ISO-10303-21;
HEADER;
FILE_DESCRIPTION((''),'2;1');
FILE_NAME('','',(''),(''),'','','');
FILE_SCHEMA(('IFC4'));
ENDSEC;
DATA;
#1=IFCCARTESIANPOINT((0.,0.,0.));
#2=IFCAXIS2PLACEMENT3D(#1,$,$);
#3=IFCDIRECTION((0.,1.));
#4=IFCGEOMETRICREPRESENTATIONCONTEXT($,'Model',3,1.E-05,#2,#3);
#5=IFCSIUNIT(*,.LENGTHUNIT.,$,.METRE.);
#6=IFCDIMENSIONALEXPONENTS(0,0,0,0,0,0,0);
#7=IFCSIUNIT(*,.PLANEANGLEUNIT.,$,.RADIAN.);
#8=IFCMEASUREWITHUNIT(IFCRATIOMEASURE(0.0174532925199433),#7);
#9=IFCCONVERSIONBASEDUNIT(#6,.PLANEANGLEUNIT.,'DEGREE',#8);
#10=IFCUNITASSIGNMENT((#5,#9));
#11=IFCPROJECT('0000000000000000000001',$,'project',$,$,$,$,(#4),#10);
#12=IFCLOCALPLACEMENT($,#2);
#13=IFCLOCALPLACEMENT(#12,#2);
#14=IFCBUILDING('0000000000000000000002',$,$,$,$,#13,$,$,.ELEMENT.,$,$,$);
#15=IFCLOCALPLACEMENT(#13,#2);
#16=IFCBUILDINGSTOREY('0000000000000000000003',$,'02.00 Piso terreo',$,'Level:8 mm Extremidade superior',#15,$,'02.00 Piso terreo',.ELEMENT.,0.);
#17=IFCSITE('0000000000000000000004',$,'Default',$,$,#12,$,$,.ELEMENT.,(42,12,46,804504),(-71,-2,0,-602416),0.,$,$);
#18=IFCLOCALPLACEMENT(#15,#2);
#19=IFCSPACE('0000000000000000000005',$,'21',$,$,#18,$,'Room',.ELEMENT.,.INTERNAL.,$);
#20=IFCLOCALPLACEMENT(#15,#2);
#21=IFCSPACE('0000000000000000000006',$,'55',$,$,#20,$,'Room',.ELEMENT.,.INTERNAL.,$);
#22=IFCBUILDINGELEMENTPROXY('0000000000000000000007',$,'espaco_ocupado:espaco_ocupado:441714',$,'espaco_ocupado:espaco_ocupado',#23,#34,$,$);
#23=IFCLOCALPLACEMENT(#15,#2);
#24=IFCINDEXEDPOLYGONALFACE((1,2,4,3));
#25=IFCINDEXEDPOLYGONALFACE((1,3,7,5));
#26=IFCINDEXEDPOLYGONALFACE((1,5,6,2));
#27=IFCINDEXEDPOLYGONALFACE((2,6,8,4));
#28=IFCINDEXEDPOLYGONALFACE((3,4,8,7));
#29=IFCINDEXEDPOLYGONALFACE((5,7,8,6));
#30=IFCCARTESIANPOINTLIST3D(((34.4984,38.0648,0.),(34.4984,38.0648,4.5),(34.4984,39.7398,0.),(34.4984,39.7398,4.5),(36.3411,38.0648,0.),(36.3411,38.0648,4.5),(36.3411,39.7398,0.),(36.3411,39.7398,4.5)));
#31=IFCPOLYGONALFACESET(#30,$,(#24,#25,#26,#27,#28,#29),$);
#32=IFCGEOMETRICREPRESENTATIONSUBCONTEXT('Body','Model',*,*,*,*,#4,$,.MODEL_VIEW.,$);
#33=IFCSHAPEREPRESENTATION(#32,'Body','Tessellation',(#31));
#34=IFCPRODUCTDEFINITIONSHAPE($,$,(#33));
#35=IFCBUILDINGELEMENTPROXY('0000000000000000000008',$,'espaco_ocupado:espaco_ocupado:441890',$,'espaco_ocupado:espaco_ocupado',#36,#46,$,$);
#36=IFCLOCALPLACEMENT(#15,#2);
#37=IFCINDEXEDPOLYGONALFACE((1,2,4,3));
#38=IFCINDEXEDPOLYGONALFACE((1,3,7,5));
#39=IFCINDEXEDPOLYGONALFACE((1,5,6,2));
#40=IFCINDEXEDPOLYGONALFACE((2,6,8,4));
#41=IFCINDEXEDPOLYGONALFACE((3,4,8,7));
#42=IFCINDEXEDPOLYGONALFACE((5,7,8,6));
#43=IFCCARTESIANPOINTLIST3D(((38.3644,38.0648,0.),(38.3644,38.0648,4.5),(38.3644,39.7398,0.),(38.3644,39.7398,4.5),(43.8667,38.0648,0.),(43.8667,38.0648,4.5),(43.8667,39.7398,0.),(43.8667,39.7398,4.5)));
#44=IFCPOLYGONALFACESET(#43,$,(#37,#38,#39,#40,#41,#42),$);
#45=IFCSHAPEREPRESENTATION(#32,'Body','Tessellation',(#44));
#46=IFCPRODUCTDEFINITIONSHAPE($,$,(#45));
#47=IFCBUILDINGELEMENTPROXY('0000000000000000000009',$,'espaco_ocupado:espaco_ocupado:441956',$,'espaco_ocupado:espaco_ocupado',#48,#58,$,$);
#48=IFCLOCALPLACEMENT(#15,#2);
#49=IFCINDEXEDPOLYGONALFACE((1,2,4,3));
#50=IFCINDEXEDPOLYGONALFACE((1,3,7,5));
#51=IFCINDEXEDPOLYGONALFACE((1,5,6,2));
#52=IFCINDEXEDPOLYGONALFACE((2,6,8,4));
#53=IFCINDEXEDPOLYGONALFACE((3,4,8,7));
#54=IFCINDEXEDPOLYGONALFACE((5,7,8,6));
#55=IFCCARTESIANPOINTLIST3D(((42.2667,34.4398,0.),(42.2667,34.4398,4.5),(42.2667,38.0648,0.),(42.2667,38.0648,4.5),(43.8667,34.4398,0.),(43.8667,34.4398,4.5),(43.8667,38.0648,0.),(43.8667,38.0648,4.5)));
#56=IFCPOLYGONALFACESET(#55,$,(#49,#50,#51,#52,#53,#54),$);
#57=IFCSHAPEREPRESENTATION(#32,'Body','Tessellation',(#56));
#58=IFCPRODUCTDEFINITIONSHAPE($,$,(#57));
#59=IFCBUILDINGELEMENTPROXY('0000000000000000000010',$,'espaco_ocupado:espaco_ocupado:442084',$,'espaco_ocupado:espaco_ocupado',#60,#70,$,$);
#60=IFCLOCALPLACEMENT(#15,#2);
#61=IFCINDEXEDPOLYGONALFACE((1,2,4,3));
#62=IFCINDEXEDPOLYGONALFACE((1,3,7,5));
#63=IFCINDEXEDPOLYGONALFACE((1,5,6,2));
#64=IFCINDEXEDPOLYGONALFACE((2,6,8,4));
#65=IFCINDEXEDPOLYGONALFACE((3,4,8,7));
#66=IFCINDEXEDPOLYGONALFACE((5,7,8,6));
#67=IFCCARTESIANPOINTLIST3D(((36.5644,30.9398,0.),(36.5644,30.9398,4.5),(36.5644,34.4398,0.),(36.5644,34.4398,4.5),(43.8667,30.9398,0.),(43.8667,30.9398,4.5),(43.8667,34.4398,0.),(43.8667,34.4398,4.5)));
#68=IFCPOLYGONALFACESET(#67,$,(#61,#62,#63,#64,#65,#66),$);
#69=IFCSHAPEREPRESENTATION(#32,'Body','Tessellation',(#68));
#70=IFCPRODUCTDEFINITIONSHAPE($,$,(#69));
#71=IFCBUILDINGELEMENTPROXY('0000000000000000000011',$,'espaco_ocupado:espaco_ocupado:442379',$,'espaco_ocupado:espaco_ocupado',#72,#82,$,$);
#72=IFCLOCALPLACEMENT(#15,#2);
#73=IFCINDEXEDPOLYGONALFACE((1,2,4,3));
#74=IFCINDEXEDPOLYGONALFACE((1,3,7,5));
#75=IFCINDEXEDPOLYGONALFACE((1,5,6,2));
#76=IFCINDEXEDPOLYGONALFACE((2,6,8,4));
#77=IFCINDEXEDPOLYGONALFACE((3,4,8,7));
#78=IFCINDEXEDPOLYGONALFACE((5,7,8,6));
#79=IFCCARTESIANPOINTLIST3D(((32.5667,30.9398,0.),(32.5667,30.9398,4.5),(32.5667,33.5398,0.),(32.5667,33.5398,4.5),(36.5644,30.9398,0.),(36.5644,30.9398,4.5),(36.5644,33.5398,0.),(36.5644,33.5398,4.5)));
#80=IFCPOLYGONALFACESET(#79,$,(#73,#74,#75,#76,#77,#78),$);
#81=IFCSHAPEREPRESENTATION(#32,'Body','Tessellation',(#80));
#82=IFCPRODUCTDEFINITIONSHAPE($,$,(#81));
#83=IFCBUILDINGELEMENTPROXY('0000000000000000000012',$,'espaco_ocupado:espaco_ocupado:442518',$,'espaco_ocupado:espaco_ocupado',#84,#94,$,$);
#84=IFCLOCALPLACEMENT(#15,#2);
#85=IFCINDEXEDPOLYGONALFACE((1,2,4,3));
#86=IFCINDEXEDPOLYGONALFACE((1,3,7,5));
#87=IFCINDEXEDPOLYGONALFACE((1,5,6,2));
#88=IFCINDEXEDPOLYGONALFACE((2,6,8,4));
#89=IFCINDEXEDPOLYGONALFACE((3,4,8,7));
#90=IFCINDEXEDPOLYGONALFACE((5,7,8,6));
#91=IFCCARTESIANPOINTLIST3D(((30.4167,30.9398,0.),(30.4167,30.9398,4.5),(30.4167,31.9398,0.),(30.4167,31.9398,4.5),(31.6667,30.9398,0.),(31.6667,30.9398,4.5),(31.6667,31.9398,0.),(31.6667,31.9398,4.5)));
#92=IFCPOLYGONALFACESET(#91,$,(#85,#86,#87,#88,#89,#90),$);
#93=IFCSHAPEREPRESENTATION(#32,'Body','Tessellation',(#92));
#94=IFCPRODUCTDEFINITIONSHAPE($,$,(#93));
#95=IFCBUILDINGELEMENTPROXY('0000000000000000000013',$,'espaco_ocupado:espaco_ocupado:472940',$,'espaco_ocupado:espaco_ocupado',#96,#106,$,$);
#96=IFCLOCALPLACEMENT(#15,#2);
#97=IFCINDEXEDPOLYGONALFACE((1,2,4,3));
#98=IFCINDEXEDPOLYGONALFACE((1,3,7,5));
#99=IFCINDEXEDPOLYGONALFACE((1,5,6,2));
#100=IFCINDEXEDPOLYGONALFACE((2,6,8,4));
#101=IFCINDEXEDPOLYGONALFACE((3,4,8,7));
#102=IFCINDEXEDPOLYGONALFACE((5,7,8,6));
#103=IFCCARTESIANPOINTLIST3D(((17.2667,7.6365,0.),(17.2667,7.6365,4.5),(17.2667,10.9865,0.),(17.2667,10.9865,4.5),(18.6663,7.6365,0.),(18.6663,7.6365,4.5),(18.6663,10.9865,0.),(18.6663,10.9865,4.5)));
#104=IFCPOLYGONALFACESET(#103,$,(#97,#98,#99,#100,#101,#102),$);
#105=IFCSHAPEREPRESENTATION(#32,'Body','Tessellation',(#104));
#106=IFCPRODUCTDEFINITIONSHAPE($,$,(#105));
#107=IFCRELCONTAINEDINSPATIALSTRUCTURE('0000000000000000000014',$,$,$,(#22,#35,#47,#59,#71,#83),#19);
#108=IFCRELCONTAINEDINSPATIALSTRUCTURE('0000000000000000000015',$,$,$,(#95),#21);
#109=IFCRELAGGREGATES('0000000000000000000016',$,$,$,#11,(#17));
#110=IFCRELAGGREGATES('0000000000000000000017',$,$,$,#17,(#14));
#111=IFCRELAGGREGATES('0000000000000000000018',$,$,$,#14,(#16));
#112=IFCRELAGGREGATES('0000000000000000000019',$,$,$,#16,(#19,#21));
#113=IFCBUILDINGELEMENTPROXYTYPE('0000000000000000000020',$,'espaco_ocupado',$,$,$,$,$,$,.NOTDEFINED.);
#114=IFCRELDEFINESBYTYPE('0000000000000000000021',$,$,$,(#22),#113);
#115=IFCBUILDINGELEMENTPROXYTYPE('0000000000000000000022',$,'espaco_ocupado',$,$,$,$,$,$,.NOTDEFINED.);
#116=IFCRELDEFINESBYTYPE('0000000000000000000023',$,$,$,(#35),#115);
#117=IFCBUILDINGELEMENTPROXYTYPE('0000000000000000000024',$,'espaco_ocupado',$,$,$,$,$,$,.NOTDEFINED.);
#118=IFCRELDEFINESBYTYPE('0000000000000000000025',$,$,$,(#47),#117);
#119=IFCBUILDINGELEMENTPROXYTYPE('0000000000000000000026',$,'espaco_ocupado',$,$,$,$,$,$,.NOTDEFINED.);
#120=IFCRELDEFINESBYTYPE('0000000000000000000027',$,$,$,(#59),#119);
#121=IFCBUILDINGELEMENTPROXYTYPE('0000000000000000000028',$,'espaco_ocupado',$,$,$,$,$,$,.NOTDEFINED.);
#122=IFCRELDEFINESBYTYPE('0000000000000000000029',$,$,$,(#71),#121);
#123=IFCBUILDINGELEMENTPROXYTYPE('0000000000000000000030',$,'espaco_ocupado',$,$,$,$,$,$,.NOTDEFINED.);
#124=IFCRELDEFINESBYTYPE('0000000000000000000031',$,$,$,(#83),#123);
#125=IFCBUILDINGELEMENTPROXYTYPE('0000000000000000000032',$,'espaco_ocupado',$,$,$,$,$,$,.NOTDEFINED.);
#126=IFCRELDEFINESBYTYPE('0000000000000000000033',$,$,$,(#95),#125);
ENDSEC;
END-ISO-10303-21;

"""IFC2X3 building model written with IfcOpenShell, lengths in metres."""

from ifc_helpers import new_model, entity, si_unit, converted_unit, direction, frame, frame_2d, origin, origin_2d_with_axis, place, context, subcontext, project, spatial, rectangle, extrude, source, transform, mapped, type_object, type_shapes, element, save


model = new_model("IFC2X3")

# Units and contexts
model_context = context("Model", 3, precision=1e-05, world=origin(), true_north=direction((0.0, 1.0)))
body_context = subcontext(model_context, "Body", "Model", "MODEL_VIEW")
ifc_project = project(units=[si_unit("LENGTHUNIT", "METRE"), converted_unit("PLANEANGLEUNIT", "DEGREE", entity("IfcRatioMeasure", 0.0174532925199433), si_unit("PLANEANGLEUNIT", "RADIAN"), dimensions=[0, 0, 0, 0, 0, 0, 0])], contexts=[model_context])

# Site, building, storey
site_placement = place(None, origin())
site = spatial("IfcSite", under=ifc_project, at=site_placement, Name="Default", CompositionType="ELEMENT", RefLatitude=(42, 12, 46, 804504), RefLongitude=(-71, -2, 0, -602416), RefElevation=0.0)
building_placement = place(site_placement, origin())
building = spatial("IfcBuilding", under=site, at=building_placement, CompositionType="ELEMENT")
storey_placement = place(building_placement, origin())
storey = spatial("IfcBuildingStorey", under=building, at=storey_placement, Name="02.00 Piso terreo", ObjectType="Level:8 mm Extremidade superior", LongName="02.00 Piso terreo", CompositionType="ELEMENT", Elevation=0.0)

# Shared definitions
space_1_placement = place(storey_placement, origin())
space_1 = spatial("IfcSpace", under=storey, at=space_1_placement, Name="21", LongName="Room", CompositionType="ELEMENT", InteriorOrExteriorSpace="INTERNAL")

# Building element proxies
building_element_proxy_type_1 = type_object("IfcBuildingElementProxyType", Name="espaco_ocupado", PredefinedType="NOTDEFINED")
shared_shape_1 = source(origin(), body_context, "Body", "SweptSolid", [
    extrude(rectangle(XDim=1.8426, YDim=1.675, at=origin_2d_with_axis()), frame((0.0, 0.0, 0.0), z_axis=(0.0, 0.0, 1.0), x_axis=(-1.0, 0.0, 0.0)), (0.0, 0.0, 1.0), 4.5),
])
type_shapes(building_element_proxy_type_1, [shared_shape_1])
proxy_1_placement = place(space_1_placement, frame((35.4197, 38.9023, 0.0)))
element("IfcBuildingElementProxy", 1, at=proxy_1_placement, inside=space_1, type_object=building_element_proxy_type_1, Name="espaco_ocupado:espaco_ocupado:441714", ObjectType="espaco_ocupado:espaco_ocupado", context=body_context, shape_type="MappedRepresentation", body=[
    mapped(shared_shape_1, transform((0.0, 0.0, 0.0), scale=1.0)),
])
building_element_proxy_type_2 = type_object("IfcBuildingElementProxyType", Name="espaco_ocupado", PredefinedType="NOTDEFINED")
shared_shape_2 = source(origin(), body_context, "Body", "SweptSolid", [
    extrude(rectangle(XDim=5.5023, YDim=1.675, at=origin_2d_with_axis()), frame((0.0, 0.0, 0.0), z_axis=(0.0, 0.0, 1.0), x_axis=(-1.0, 0.0, 0.0)), (0.0, 0.0, 1.0), 4.5),
])
type_shapes(building_element_proxy_type_2, [shared_shape_2])
proxy_2_placement = place(space_1_placement, frame((41.1156, 38.9023, 0.0)))
element("IfcBuildingElementProxy", 2, at=proxy_2_placement, inside=space_1, type_object=building_element_proxy_type_2, Name="espaco_ocupado:espaco_ocupado:441890", ObjectType="espaco_ocupado:espaco_ocupado", context=body_context, shape_type="MappedRepresentation", body=[
    mapped(shared_shape_2, transform((0.0, 0.0, 0.0), scale=1.0)),
])
building_element_proxy_type_3 = type_object("IfcBuildingElementProxyType", Name="espaco_ocupado", PredefinedType="NOTDEFINED")
shared_shape_3 = source(origin(), body_context, "Body", "SweptSolid", [
    extrude(rectangle(XDim=1.6, YDim=3.625, at=frame_2d((0.0, 0.0), x_axis=(1.0, 0.0))), frame((0.0, 0.0, 0.0), z_axis=(0.0, 0.0, 1.0), x_axis=(-1.0, 0.0, 0.0)), (0.0, 0.0, 1.0), 4.5),
])
type_shapes(building_element_proxy_type_3, [shared_shape_3])
proxy_3_placement = place(space_1_placement, frame((43.0667, 36.2523, 0.0)))
element("IfcBuildingElementProxy", 3, at=proxy_3_placement, inside=space_1, type_object=building_element_proxy_type_3, Name="espaco_ocupado:espaco_ocupado:441956", ObjectType="espaco_ocupado:espaco_ocupado", context=body_context, shape_type="MappedRepresentation", body=[
    mapped(shared_shape_3, transform((0.0, 0.0, 0.0), scale=1.0)),
])
building_element_proxy_type_4 = type_object("IfcBuildingElementProxyType", Name="espaco_ocupado", PredefinedType="NOTDEFINED")
shared_shape_4 = source(origin(), body_context, "Body", "SweptSolid", [
    extrude(rectangle(XDim=7.3023, YDim=3.5, at=origin_2d_with_axis()), frame((0.0, 0.0, 0.0), z_axis=(0.0, 0.0, 1.0), x_axis=(-1.0, 0.0, 0.0)), (0.0, 0.0, 1.0), 4.5),
])
type_shapes(building_element_proxy_type_4, [shared_shape_4])
proxy_4_placement = place(space_1_placement, frame((40.2156, 32.6898, 0.0)))
element("IfcBuildingElementProxy", 4, at=proxy_4_placement, inside=space_1, type_object=building_element_proxy_type_4, Name="espaco_ocupado:espaco_ocupado:442084", ObjectType="espaco_ocupado:espaco_ocupado", context=body_context, shape_type="MappedRepresentation", body=[
    mapped(shared_shape_4, transform((0.0, 0.0, 0.0), scale=1.0)),
])
building_element_proxy_type_5 = type_object("IfcBuildingElementProxyType", Name="espaco_ocupado", PredefinedType="NOTDEFINED")
shared_shape_5 = source(origin(), body_context, "Body", "SweptSolid", [
    extrude(rectangle(XDim=3.9977, YDim=2.6, at=origin_2d_with_axis()), frame((0.0, 0.0, 0.0), z_axis=(0.0, 0.0, 1.0), x_axis=(-1.0, 0.0, 0.0)), (0.0, 0.0, 1.0), 4.5),
])
type_shapes(building_element_proxy_type_5, [shared_shape_5])
proxy_5_placement = place(space_1_placement, frame((34.5656, 32.2398, 0.0)))
element("IfcBuildingElementProxy", 5, at=proxy_5_placement, inside=space_1, type_object=building_element_proxy_type_5, Name="espaco_ocupado:espaco_ocupado:442379", ObjectType="espaco_ocupado:espaco_ocupado", context=body_context, shape_type="MappedRepresentation", body=[
    mapped(shared_shape_5, transform((0.0, 0.0, 0.0), scale=1.0)),
])
building_element_proxy_type_6 = type_object("IfcBuildingElementProxyType", Name="espaco_ocupado", PredefinedType="NOTDEFINED")
shared_shape_6 = source(origin(), body_context, "Body", "SweptSolid", [
    extrude(rectangle(XDim=1.25, YDim=1.0, at=origin_2d_with_axis()), frame((0.0, 0.0, 0.0), z_axis=(0.0, 0.0, 1.0), x_axis=(-1.0, 0.0, 0.0)), (0.0, 0.0, 1.0), 4.5),
])
type_shapes(building_element_proxy_type_6, [shared_shape_6])
proxy_6_placement = place(space_1_placement, frame((31.0417, 31.4398, 0.0)))
element("IfcBuildingElementProxy", 6, at=proxy_6_placement, inside=space_1, type_object=building_element_proxy_type_6, Name="espaco_ocupado:espaco_ocupado:442518", ObjectType="espaco_ocupado:espaco_ocupado", context=body_context, shape_type="MappedRepresentation", body=[
    mapped(shared_shape_6, transform((0.0, 0.0, 0.0), scale=1.0)),
])

# Shared definitions
space_2_placement = place(storey_placement, origin())
space_2 = spatial("IfcSpace", under=storey, at=space_2_placement, Name="55", LongName="Room", CompositionType="ELEMENT", InteriorOrExteriorSpace="INTERNAL")

# Building element proxy
building_element_proxy_type_7 = type_object("IfcBuildingElementProxyType", Name="espaco_ocupado", PredefinedType="NOTDEFINED")
shared_shape_7 = source(origin(), body_context, "Body", "SweptSolid", [
    extrude(rectangle(XDim=1.3996, YDim=3.35, at=origin_2d_with_axis()), frame((0.0, 0.0, 0.0), z_axis=(0.0, 0.0, 1.0), x_axis=(-1.0, 0.0, 0.0)), (0.0, 0.0, 1.0), 4.5),
])
type_shapes(building_element_proxy_type_7, [shared_shape_7])
proxy_7_placement = place(space_2_placement, frame((17.9665, 9.3115, 0.0)))
element("IfcBuildingElementProxy", 7, at=proxy_7_placement, inside=space_2, type_object=building_element_proxy_type_7, Name="espaco_ocupado:espaco_ocupado:472940", ObjectType="espaco_ocupado:espaco_ocupado", context=body_context, shape_type="MappedRepresentation", body=[
    mapped(shared_shape_7, transform((0.0, 0.0, 0.0), scale=1.0)),
])

save(model, "model.ifc")
